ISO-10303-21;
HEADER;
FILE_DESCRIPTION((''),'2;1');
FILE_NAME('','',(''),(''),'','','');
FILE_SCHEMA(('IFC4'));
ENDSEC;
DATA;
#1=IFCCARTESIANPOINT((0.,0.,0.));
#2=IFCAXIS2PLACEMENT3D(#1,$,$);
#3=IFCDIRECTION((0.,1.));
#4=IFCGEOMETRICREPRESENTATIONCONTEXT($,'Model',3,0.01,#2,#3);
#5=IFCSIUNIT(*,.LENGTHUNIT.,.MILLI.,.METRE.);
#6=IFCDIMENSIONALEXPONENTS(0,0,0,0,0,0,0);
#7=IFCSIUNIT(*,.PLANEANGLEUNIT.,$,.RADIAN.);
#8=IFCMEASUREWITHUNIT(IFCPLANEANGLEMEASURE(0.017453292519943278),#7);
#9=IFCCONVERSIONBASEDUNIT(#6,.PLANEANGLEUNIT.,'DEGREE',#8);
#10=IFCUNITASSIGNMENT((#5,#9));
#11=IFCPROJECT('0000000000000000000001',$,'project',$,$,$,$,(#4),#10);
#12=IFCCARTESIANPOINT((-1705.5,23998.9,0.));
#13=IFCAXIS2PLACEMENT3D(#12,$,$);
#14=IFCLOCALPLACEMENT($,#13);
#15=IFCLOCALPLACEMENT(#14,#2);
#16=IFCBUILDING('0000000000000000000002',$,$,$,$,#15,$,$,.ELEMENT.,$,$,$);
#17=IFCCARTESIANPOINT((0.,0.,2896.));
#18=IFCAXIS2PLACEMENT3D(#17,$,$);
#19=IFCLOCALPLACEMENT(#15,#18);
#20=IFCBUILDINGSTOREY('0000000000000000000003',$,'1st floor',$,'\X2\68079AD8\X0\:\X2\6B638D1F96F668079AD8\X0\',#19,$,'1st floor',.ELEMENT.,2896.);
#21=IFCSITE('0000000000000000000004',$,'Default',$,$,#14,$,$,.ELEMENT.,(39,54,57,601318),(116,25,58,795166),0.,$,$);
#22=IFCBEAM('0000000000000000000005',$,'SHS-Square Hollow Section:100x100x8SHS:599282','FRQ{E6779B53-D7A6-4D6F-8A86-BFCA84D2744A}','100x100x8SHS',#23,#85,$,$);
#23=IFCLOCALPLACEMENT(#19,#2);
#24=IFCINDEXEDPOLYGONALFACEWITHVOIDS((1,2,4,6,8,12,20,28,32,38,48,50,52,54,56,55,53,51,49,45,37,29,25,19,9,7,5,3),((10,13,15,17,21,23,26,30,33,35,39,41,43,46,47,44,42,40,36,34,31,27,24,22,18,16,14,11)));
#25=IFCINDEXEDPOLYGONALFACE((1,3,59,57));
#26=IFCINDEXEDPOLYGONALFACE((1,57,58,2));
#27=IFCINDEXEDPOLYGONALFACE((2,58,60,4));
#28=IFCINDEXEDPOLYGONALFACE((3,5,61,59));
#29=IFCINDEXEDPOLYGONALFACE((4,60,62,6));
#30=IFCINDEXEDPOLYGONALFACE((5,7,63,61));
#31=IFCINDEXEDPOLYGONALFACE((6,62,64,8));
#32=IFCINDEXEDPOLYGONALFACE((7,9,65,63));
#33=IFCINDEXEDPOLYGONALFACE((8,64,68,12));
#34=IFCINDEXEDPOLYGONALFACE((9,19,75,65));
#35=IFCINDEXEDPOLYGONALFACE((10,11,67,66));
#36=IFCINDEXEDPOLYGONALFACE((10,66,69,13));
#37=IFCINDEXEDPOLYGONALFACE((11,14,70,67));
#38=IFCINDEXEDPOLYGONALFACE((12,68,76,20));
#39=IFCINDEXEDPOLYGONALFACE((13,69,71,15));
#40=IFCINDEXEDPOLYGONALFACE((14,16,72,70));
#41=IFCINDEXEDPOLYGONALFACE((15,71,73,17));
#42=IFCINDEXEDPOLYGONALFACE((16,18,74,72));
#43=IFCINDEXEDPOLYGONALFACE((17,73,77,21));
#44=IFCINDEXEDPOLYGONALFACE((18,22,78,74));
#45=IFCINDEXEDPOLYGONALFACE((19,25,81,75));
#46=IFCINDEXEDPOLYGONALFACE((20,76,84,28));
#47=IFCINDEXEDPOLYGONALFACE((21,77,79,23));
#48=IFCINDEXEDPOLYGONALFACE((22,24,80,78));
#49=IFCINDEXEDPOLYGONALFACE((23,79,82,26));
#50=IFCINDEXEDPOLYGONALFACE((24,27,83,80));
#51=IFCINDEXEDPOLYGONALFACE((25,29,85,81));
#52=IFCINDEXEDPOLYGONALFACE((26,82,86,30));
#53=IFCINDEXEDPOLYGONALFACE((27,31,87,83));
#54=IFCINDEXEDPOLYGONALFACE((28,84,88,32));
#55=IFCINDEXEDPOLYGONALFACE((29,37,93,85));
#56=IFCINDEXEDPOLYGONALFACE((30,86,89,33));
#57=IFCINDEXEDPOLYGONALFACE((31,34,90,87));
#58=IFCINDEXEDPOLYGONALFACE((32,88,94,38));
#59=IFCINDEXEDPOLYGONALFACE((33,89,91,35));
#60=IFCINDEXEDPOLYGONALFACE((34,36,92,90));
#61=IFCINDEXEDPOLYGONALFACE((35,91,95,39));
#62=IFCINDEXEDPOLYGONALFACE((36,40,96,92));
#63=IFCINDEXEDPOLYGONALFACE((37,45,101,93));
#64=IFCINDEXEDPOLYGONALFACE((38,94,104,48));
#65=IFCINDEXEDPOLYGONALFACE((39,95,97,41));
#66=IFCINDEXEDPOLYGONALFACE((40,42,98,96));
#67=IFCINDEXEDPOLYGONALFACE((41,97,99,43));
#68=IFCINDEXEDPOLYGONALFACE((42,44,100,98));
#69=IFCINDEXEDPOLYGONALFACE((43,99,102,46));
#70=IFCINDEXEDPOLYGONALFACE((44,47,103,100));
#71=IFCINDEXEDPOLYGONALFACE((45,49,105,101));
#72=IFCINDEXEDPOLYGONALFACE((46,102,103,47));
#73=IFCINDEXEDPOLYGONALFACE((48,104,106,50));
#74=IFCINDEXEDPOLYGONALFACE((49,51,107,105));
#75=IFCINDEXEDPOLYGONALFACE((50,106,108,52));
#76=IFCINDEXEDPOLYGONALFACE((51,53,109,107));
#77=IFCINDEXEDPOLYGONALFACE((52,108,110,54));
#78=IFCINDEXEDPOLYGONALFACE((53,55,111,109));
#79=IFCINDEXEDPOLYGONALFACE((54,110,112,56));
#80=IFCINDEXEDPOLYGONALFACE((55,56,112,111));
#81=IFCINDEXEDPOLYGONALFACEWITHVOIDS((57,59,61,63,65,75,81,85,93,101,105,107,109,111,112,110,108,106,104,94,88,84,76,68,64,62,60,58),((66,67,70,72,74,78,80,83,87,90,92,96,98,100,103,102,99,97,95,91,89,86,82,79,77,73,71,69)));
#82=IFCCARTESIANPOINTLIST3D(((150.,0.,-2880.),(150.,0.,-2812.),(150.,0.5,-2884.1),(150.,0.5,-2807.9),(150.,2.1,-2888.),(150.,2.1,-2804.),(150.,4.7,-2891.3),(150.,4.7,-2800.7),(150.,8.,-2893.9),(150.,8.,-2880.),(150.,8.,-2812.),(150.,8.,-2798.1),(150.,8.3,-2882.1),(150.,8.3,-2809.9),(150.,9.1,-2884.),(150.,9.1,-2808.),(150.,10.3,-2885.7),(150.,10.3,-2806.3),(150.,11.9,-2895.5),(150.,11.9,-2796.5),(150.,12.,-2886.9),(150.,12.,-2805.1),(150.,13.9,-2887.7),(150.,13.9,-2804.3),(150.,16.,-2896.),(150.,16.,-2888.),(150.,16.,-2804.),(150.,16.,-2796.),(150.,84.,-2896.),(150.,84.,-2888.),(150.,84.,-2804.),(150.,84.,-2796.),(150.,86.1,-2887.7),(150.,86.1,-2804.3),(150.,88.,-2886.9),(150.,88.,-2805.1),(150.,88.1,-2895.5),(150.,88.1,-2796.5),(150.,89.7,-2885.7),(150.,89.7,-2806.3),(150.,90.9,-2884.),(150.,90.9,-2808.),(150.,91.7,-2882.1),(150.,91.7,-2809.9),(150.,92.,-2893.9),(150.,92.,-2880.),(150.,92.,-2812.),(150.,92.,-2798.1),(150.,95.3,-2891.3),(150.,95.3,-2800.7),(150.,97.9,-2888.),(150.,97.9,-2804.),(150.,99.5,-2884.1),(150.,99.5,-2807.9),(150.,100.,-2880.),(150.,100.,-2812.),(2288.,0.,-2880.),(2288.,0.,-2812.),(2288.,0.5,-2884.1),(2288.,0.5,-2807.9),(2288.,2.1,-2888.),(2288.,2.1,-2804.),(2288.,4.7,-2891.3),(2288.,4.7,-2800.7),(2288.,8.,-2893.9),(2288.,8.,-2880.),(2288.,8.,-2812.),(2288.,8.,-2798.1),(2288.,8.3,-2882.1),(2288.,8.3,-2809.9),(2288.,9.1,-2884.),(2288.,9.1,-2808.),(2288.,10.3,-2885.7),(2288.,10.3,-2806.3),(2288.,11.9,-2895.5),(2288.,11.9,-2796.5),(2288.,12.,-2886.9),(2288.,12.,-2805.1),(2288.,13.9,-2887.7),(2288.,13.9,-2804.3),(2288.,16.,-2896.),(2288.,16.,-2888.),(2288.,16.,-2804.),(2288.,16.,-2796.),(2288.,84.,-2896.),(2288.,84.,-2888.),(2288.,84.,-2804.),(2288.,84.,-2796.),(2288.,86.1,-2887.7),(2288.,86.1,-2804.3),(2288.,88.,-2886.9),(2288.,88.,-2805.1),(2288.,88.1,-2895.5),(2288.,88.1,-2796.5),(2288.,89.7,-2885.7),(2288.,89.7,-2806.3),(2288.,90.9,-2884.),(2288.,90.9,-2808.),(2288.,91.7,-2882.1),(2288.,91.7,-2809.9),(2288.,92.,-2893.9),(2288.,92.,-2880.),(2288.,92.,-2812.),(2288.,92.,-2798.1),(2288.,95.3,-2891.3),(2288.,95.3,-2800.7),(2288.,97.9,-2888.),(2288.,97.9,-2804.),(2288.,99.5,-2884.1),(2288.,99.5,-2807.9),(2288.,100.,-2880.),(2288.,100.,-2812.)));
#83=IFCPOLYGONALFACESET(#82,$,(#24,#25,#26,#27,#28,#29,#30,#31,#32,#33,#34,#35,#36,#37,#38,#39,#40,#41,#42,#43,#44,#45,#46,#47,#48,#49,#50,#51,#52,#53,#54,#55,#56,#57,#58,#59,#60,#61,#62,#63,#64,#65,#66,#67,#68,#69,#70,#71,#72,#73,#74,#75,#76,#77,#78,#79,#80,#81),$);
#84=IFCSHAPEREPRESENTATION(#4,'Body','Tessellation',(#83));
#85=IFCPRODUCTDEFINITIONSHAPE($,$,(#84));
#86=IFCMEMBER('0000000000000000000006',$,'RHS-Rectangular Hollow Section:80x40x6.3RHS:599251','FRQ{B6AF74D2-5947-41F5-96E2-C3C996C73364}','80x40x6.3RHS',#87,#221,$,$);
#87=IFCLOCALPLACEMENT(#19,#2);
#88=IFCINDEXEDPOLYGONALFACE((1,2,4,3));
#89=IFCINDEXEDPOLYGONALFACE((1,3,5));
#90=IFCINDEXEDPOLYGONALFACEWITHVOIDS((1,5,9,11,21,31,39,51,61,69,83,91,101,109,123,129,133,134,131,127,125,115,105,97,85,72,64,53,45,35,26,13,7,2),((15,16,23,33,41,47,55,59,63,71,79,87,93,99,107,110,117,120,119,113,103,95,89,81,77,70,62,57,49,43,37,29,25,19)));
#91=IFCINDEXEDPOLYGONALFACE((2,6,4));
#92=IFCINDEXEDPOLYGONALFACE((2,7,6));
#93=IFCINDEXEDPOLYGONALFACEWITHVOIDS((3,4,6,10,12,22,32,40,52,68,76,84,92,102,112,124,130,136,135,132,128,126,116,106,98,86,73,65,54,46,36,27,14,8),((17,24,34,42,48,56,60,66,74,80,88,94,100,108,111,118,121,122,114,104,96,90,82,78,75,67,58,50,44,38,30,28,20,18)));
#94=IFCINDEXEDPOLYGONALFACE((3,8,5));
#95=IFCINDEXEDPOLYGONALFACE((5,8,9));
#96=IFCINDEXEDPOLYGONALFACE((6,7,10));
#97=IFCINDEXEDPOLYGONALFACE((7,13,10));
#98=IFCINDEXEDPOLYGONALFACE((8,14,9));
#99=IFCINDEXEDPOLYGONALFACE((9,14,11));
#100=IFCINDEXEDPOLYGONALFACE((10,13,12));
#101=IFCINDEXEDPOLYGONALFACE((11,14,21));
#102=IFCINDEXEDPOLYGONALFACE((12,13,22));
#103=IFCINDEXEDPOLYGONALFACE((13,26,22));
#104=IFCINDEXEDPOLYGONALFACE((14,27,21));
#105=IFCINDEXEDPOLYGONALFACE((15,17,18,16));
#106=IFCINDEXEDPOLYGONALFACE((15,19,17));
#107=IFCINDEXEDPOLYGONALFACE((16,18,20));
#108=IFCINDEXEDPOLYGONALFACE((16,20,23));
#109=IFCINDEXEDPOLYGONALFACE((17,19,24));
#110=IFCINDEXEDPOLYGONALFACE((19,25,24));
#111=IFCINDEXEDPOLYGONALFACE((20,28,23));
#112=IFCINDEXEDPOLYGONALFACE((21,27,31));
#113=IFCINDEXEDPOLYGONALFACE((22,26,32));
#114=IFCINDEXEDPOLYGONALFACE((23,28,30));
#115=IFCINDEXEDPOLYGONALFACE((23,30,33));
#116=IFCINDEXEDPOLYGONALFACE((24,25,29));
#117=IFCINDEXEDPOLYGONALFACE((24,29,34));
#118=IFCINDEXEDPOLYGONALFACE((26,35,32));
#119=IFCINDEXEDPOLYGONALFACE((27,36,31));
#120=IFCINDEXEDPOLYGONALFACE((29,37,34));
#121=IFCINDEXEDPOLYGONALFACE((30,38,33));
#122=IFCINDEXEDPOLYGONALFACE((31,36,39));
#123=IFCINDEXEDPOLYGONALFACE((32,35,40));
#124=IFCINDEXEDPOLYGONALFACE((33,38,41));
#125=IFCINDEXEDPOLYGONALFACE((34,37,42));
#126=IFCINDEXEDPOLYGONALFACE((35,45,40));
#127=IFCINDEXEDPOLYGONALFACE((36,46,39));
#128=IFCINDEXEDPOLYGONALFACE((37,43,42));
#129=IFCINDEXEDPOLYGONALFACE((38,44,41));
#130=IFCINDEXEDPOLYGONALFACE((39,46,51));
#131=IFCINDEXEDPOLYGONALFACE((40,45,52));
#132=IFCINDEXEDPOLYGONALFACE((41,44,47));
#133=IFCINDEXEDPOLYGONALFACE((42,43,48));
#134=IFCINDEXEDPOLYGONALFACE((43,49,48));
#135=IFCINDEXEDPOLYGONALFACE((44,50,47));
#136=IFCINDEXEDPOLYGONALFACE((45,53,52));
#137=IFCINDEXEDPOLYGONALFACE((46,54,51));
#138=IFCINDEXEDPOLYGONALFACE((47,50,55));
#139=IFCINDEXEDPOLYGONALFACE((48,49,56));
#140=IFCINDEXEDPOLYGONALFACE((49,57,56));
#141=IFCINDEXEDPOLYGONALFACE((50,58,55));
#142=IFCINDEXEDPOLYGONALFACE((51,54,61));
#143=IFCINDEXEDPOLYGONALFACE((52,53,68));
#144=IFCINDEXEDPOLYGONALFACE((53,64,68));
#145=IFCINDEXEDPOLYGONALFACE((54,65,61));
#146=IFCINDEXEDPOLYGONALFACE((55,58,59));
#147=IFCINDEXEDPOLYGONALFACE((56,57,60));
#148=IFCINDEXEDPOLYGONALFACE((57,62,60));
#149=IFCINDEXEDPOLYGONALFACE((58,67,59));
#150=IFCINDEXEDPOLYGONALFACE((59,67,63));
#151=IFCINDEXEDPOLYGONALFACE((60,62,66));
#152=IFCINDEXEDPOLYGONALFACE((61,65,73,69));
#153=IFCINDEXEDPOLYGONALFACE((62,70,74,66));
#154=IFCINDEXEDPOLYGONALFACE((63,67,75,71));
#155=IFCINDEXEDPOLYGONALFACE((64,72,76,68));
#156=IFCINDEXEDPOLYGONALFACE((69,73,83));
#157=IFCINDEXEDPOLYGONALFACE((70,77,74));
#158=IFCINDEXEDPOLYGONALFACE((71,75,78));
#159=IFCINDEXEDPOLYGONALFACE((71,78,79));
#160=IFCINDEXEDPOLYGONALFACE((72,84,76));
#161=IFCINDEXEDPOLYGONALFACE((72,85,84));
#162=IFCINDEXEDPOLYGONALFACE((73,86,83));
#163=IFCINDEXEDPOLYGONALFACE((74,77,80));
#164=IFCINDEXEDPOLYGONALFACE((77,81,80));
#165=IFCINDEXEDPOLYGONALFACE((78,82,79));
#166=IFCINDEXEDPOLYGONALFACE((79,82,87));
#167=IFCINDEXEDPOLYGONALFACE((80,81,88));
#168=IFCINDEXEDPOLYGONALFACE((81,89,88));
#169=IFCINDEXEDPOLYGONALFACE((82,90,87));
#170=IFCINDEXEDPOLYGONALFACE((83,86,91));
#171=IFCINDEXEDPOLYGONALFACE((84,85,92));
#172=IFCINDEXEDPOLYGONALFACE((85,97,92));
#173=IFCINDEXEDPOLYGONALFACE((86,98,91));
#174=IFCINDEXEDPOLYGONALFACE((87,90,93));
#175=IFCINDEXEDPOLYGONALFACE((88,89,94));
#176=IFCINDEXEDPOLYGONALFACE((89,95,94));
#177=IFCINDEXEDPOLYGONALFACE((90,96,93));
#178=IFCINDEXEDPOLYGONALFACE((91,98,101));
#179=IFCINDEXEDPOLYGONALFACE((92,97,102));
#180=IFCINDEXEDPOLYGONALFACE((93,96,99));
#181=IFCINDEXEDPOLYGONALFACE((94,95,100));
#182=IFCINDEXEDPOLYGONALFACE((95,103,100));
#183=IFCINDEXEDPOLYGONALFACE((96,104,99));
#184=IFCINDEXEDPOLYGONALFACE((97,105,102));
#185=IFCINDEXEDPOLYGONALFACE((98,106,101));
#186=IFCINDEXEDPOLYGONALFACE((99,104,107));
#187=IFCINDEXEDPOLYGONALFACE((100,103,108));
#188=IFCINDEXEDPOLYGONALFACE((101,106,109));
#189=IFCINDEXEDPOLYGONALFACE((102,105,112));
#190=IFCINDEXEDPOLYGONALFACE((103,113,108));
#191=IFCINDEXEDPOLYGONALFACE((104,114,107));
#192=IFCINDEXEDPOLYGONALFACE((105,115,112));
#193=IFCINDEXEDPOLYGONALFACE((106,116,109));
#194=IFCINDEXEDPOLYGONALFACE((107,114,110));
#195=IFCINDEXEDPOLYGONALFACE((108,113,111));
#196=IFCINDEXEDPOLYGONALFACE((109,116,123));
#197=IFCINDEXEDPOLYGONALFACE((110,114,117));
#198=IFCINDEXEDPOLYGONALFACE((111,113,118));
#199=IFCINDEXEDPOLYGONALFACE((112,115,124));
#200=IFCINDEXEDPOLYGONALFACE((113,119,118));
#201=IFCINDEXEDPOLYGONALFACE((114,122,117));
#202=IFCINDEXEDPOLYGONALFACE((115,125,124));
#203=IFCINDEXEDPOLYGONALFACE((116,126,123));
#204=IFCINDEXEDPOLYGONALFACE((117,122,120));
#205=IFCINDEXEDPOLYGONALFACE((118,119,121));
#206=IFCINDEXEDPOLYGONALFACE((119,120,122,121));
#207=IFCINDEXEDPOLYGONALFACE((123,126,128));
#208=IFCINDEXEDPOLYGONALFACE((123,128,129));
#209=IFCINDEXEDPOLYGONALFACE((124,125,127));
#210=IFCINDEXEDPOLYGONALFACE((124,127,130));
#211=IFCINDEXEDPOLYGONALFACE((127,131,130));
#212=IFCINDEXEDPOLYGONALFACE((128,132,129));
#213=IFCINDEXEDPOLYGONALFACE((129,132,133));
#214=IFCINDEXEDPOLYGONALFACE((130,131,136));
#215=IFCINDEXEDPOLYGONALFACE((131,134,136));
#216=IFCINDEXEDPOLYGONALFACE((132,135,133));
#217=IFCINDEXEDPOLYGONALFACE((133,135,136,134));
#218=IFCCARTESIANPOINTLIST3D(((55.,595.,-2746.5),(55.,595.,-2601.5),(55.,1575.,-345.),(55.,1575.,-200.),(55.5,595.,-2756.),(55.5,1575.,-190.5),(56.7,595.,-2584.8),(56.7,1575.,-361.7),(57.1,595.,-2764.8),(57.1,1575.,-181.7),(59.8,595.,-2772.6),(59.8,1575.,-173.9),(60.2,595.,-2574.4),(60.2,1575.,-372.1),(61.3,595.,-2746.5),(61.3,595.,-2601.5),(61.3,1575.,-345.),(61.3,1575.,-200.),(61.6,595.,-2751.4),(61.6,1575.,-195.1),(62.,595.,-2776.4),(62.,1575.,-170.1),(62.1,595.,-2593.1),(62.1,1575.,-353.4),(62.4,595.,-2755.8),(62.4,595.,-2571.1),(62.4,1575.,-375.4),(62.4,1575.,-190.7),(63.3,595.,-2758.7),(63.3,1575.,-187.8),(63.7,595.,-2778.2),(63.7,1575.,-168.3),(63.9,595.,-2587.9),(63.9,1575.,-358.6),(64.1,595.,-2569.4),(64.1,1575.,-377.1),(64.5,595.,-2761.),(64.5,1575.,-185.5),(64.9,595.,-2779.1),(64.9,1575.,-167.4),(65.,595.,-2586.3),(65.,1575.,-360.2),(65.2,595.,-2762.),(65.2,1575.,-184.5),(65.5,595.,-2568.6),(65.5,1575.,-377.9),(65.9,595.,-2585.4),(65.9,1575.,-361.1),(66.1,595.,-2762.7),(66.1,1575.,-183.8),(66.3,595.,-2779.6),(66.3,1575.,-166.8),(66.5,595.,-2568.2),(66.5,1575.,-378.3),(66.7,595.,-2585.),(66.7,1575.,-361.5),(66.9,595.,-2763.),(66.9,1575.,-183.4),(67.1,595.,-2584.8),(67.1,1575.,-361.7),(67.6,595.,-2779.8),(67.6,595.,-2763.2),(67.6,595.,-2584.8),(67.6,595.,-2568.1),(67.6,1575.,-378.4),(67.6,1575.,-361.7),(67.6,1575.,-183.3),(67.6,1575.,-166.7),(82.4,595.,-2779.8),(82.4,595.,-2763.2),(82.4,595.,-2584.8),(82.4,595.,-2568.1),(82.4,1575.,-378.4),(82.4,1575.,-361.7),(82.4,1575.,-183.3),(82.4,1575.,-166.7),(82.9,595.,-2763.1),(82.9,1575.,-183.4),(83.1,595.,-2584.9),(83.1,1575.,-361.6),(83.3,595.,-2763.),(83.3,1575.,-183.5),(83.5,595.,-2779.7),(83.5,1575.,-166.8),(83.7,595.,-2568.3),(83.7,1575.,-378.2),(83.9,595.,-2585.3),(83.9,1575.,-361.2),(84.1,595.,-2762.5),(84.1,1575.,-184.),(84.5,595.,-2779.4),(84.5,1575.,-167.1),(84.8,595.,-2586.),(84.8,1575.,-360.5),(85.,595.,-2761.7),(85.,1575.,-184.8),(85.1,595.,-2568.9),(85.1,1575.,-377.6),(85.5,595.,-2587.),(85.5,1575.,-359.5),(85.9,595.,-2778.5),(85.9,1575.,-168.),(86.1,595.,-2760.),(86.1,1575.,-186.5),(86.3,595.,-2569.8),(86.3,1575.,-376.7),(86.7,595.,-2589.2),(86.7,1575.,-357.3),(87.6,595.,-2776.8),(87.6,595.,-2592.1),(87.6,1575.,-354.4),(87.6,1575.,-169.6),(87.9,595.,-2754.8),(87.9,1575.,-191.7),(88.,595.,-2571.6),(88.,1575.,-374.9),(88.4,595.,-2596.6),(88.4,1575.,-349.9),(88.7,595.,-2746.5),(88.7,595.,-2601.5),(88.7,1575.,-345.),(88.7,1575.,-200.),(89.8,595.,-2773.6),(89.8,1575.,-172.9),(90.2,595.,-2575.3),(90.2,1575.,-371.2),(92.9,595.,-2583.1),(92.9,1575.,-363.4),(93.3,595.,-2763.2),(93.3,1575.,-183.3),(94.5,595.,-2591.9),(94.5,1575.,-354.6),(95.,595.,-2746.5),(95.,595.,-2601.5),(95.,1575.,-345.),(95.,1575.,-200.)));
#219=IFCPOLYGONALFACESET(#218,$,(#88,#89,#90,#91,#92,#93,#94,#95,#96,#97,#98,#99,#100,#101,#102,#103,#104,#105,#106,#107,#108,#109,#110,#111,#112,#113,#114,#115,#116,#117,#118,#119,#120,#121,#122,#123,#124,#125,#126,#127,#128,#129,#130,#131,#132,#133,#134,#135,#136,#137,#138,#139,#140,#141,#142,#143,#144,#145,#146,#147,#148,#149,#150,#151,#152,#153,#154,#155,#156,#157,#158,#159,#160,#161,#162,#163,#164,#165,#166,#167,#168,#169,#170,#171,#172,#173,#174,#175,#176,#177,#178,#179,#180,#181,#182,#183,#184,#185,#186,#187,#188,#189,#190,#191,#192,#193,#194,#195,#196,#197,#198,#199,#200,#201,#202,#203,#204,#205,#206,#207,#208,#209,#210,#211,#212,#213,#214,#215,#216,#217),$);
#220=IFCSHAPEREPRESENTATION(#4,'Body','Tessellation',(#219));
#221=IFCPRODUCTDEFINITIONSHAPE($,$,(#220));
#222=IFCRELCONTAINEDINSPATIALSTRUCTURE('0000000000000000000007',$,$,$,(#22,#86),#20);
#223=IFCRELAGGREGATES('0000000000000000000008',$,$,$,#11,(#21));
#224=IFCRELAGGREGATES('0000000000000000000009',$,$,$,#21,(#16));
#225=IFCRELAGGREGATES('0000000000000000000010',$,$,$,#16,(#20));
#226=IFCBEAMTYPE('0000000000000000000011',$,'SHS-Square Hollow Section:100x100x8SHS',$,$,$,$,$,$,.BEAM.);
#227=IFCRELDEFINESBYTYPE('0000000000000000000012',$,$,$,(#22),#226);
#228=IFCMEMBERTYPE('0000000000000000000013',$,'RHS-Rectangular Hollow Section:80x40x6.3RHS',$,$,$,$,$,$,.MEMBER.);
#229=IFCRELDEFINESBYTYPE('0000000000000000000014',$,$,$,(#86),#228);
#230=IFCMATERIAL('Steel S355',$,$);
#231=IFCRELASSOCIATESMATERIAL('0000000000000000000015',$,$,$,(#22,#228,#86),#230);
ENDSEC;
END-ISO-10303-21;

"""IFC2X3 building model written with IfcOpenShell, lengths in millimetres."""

from ifc_helpers import new_model, entity, si_unit, converted_unit, direction, frame, origin, origin_2d, place, context, project, spatial, hollow_rectangle, extrude, clip, halfspace, material, type_object, element, save


model = new_model("IFC2X3")

# Units and contexts
model_context = context("Model", 3, precision=0.01, world=origin(), true_north=direction((0.0, 1.0)))
ifc_project = project(units=[si_unit("LENGTHUNIT", "METRE", prefix="MILLI"), converted_unit("PLANEANGLEUNIT", "DEGREE", entity("IfcPlaneAngleMeasure", 0.017453292519943278), si_unit("PLANEANGLEUNIT", "RADIAN"), dimensions=[0, 0, 0, 0, 0, 0, 0])], contexts=[model_context])

# Site, building, storey
site_placement = place(None, frame((-1705.5, 23998.9, 0.0)))
site = spatial("IfcSite", under=ifc_project, at=site_placement, Name="Default", CompositionType="ELEMENT", RefLatitude=(39, 54, 57, 601318), RefLongitude=(116, 25, 58, 795166), RefElevation=0.0)
building_placement = place(site_placement, origin())
building = spatial("IfcBuilding", under=site, at=building_placement, CompositionType="ELEMENT")
storey_placement = place(building_placement, frame((0.0, 0.0, 2896.0)))
storey = spatial("IfcBuildingStorey", under=building, at=storey_placement, Name="1st floor", ObjectType="标高:正负零标高", LongName="1st floor", CompositionType="ELEMENT", Elevation=2896.0)

# Shared definitions
ifc_material_1 = material(Name="Steel S355")

# Beam
beam_type_1 = type_object("IfcBeamType", Name="SHS-Square Hollow Section:100x100x8SHS", PredefinedType="BEAM")
beam_1_placement = place(storey_placement, frame((-57.7, 50.0, -2846.0), z_axis=(-1.0, 0.0, 0.0), x_axis=(0.0, -1.0, 0.0)))
element("IfcBeam", 1, at=beam_1_placement, inside=storey, type_object=beam_type_1, material=ifc_material_1, Name="SHS-Square Hollow Section:100x100x8SHS:599282", Description="FRQ{E6779B53-D7A6-4D6F-8A86-BFCA84D2744A}", ObjectType="100x100x8SHS", context=model_context, shape_type="Clipping", body=[
    clip(clip(extrude(hollow_rectangle(XDim=100.0, YDim=100.0, WallThickness=8.0, InnerFilletRadius=8.0, OuterFilletRadius=16.0, at=origin_2d()), origin(), (0.0, 0.0, -1.0), 2551.4), halfspace(frame((50.0, -50.0, -2345.7), z_axis=(0.0, 0.0, 1.0), x_axis=(1.0, 0.0, 0.0)), True)), halfspace(frame((50.0, -50.0, -207.7), z_axis=(0.0, 0.0, -1.0), x_axis=(-1.0, 0.0, 0.0)), True)),
])

# Member
member_type_1 = type_object("IfcMemberType", Name="RHS-Rectangular Hollow Section:80x40x6.3RHS", PredefinedType="MEMBER", material=ifc_material_1)
member_1_placement = place(storey_placement, frame((75.0, 490.3, -2930.6), z_axis=(0.0, -0.377836, -0.925872), x_axis=(1.0, 0.0, 0.0)))
element("IfcMember", 2, at=member_1_placement, inside=storey, type_object=member_type_1, material=ifc_material_1, Name="RHS-Rectangular Hollow Section:80x40x6.3RHS:599251", Description="FRQ{B6AF74D2-5947-41F5-96E2-C3C996C73364}", ObjectType="80x40x6.3RHS", context=model_context, shape_type="Clipping", body=[
    clip(clip(extrude(hollow_rectangle(XDim=40.0, YDim=80.0, WallThickness=6.3, InnerFilletRadius=6.3, OuterFilletRadius=12.6, at=origin_2d()), origin(), (0.0, 0.0, -1.0), 3121.6), halfspace(frame((-75.0, -83.9, -71.6), z_axis=(0.0, -0.925872, -0.377836), x_axis=(-1.0, 0.0, 0.0)), True)), halfspace(frame((-75.0, -991.2, -441.9), z_axis=(0.0, 0.925872, 0.377836), x_axis=(1.0, 0.0, 0.0)), True)),
])

save(model, "model.ifc")
